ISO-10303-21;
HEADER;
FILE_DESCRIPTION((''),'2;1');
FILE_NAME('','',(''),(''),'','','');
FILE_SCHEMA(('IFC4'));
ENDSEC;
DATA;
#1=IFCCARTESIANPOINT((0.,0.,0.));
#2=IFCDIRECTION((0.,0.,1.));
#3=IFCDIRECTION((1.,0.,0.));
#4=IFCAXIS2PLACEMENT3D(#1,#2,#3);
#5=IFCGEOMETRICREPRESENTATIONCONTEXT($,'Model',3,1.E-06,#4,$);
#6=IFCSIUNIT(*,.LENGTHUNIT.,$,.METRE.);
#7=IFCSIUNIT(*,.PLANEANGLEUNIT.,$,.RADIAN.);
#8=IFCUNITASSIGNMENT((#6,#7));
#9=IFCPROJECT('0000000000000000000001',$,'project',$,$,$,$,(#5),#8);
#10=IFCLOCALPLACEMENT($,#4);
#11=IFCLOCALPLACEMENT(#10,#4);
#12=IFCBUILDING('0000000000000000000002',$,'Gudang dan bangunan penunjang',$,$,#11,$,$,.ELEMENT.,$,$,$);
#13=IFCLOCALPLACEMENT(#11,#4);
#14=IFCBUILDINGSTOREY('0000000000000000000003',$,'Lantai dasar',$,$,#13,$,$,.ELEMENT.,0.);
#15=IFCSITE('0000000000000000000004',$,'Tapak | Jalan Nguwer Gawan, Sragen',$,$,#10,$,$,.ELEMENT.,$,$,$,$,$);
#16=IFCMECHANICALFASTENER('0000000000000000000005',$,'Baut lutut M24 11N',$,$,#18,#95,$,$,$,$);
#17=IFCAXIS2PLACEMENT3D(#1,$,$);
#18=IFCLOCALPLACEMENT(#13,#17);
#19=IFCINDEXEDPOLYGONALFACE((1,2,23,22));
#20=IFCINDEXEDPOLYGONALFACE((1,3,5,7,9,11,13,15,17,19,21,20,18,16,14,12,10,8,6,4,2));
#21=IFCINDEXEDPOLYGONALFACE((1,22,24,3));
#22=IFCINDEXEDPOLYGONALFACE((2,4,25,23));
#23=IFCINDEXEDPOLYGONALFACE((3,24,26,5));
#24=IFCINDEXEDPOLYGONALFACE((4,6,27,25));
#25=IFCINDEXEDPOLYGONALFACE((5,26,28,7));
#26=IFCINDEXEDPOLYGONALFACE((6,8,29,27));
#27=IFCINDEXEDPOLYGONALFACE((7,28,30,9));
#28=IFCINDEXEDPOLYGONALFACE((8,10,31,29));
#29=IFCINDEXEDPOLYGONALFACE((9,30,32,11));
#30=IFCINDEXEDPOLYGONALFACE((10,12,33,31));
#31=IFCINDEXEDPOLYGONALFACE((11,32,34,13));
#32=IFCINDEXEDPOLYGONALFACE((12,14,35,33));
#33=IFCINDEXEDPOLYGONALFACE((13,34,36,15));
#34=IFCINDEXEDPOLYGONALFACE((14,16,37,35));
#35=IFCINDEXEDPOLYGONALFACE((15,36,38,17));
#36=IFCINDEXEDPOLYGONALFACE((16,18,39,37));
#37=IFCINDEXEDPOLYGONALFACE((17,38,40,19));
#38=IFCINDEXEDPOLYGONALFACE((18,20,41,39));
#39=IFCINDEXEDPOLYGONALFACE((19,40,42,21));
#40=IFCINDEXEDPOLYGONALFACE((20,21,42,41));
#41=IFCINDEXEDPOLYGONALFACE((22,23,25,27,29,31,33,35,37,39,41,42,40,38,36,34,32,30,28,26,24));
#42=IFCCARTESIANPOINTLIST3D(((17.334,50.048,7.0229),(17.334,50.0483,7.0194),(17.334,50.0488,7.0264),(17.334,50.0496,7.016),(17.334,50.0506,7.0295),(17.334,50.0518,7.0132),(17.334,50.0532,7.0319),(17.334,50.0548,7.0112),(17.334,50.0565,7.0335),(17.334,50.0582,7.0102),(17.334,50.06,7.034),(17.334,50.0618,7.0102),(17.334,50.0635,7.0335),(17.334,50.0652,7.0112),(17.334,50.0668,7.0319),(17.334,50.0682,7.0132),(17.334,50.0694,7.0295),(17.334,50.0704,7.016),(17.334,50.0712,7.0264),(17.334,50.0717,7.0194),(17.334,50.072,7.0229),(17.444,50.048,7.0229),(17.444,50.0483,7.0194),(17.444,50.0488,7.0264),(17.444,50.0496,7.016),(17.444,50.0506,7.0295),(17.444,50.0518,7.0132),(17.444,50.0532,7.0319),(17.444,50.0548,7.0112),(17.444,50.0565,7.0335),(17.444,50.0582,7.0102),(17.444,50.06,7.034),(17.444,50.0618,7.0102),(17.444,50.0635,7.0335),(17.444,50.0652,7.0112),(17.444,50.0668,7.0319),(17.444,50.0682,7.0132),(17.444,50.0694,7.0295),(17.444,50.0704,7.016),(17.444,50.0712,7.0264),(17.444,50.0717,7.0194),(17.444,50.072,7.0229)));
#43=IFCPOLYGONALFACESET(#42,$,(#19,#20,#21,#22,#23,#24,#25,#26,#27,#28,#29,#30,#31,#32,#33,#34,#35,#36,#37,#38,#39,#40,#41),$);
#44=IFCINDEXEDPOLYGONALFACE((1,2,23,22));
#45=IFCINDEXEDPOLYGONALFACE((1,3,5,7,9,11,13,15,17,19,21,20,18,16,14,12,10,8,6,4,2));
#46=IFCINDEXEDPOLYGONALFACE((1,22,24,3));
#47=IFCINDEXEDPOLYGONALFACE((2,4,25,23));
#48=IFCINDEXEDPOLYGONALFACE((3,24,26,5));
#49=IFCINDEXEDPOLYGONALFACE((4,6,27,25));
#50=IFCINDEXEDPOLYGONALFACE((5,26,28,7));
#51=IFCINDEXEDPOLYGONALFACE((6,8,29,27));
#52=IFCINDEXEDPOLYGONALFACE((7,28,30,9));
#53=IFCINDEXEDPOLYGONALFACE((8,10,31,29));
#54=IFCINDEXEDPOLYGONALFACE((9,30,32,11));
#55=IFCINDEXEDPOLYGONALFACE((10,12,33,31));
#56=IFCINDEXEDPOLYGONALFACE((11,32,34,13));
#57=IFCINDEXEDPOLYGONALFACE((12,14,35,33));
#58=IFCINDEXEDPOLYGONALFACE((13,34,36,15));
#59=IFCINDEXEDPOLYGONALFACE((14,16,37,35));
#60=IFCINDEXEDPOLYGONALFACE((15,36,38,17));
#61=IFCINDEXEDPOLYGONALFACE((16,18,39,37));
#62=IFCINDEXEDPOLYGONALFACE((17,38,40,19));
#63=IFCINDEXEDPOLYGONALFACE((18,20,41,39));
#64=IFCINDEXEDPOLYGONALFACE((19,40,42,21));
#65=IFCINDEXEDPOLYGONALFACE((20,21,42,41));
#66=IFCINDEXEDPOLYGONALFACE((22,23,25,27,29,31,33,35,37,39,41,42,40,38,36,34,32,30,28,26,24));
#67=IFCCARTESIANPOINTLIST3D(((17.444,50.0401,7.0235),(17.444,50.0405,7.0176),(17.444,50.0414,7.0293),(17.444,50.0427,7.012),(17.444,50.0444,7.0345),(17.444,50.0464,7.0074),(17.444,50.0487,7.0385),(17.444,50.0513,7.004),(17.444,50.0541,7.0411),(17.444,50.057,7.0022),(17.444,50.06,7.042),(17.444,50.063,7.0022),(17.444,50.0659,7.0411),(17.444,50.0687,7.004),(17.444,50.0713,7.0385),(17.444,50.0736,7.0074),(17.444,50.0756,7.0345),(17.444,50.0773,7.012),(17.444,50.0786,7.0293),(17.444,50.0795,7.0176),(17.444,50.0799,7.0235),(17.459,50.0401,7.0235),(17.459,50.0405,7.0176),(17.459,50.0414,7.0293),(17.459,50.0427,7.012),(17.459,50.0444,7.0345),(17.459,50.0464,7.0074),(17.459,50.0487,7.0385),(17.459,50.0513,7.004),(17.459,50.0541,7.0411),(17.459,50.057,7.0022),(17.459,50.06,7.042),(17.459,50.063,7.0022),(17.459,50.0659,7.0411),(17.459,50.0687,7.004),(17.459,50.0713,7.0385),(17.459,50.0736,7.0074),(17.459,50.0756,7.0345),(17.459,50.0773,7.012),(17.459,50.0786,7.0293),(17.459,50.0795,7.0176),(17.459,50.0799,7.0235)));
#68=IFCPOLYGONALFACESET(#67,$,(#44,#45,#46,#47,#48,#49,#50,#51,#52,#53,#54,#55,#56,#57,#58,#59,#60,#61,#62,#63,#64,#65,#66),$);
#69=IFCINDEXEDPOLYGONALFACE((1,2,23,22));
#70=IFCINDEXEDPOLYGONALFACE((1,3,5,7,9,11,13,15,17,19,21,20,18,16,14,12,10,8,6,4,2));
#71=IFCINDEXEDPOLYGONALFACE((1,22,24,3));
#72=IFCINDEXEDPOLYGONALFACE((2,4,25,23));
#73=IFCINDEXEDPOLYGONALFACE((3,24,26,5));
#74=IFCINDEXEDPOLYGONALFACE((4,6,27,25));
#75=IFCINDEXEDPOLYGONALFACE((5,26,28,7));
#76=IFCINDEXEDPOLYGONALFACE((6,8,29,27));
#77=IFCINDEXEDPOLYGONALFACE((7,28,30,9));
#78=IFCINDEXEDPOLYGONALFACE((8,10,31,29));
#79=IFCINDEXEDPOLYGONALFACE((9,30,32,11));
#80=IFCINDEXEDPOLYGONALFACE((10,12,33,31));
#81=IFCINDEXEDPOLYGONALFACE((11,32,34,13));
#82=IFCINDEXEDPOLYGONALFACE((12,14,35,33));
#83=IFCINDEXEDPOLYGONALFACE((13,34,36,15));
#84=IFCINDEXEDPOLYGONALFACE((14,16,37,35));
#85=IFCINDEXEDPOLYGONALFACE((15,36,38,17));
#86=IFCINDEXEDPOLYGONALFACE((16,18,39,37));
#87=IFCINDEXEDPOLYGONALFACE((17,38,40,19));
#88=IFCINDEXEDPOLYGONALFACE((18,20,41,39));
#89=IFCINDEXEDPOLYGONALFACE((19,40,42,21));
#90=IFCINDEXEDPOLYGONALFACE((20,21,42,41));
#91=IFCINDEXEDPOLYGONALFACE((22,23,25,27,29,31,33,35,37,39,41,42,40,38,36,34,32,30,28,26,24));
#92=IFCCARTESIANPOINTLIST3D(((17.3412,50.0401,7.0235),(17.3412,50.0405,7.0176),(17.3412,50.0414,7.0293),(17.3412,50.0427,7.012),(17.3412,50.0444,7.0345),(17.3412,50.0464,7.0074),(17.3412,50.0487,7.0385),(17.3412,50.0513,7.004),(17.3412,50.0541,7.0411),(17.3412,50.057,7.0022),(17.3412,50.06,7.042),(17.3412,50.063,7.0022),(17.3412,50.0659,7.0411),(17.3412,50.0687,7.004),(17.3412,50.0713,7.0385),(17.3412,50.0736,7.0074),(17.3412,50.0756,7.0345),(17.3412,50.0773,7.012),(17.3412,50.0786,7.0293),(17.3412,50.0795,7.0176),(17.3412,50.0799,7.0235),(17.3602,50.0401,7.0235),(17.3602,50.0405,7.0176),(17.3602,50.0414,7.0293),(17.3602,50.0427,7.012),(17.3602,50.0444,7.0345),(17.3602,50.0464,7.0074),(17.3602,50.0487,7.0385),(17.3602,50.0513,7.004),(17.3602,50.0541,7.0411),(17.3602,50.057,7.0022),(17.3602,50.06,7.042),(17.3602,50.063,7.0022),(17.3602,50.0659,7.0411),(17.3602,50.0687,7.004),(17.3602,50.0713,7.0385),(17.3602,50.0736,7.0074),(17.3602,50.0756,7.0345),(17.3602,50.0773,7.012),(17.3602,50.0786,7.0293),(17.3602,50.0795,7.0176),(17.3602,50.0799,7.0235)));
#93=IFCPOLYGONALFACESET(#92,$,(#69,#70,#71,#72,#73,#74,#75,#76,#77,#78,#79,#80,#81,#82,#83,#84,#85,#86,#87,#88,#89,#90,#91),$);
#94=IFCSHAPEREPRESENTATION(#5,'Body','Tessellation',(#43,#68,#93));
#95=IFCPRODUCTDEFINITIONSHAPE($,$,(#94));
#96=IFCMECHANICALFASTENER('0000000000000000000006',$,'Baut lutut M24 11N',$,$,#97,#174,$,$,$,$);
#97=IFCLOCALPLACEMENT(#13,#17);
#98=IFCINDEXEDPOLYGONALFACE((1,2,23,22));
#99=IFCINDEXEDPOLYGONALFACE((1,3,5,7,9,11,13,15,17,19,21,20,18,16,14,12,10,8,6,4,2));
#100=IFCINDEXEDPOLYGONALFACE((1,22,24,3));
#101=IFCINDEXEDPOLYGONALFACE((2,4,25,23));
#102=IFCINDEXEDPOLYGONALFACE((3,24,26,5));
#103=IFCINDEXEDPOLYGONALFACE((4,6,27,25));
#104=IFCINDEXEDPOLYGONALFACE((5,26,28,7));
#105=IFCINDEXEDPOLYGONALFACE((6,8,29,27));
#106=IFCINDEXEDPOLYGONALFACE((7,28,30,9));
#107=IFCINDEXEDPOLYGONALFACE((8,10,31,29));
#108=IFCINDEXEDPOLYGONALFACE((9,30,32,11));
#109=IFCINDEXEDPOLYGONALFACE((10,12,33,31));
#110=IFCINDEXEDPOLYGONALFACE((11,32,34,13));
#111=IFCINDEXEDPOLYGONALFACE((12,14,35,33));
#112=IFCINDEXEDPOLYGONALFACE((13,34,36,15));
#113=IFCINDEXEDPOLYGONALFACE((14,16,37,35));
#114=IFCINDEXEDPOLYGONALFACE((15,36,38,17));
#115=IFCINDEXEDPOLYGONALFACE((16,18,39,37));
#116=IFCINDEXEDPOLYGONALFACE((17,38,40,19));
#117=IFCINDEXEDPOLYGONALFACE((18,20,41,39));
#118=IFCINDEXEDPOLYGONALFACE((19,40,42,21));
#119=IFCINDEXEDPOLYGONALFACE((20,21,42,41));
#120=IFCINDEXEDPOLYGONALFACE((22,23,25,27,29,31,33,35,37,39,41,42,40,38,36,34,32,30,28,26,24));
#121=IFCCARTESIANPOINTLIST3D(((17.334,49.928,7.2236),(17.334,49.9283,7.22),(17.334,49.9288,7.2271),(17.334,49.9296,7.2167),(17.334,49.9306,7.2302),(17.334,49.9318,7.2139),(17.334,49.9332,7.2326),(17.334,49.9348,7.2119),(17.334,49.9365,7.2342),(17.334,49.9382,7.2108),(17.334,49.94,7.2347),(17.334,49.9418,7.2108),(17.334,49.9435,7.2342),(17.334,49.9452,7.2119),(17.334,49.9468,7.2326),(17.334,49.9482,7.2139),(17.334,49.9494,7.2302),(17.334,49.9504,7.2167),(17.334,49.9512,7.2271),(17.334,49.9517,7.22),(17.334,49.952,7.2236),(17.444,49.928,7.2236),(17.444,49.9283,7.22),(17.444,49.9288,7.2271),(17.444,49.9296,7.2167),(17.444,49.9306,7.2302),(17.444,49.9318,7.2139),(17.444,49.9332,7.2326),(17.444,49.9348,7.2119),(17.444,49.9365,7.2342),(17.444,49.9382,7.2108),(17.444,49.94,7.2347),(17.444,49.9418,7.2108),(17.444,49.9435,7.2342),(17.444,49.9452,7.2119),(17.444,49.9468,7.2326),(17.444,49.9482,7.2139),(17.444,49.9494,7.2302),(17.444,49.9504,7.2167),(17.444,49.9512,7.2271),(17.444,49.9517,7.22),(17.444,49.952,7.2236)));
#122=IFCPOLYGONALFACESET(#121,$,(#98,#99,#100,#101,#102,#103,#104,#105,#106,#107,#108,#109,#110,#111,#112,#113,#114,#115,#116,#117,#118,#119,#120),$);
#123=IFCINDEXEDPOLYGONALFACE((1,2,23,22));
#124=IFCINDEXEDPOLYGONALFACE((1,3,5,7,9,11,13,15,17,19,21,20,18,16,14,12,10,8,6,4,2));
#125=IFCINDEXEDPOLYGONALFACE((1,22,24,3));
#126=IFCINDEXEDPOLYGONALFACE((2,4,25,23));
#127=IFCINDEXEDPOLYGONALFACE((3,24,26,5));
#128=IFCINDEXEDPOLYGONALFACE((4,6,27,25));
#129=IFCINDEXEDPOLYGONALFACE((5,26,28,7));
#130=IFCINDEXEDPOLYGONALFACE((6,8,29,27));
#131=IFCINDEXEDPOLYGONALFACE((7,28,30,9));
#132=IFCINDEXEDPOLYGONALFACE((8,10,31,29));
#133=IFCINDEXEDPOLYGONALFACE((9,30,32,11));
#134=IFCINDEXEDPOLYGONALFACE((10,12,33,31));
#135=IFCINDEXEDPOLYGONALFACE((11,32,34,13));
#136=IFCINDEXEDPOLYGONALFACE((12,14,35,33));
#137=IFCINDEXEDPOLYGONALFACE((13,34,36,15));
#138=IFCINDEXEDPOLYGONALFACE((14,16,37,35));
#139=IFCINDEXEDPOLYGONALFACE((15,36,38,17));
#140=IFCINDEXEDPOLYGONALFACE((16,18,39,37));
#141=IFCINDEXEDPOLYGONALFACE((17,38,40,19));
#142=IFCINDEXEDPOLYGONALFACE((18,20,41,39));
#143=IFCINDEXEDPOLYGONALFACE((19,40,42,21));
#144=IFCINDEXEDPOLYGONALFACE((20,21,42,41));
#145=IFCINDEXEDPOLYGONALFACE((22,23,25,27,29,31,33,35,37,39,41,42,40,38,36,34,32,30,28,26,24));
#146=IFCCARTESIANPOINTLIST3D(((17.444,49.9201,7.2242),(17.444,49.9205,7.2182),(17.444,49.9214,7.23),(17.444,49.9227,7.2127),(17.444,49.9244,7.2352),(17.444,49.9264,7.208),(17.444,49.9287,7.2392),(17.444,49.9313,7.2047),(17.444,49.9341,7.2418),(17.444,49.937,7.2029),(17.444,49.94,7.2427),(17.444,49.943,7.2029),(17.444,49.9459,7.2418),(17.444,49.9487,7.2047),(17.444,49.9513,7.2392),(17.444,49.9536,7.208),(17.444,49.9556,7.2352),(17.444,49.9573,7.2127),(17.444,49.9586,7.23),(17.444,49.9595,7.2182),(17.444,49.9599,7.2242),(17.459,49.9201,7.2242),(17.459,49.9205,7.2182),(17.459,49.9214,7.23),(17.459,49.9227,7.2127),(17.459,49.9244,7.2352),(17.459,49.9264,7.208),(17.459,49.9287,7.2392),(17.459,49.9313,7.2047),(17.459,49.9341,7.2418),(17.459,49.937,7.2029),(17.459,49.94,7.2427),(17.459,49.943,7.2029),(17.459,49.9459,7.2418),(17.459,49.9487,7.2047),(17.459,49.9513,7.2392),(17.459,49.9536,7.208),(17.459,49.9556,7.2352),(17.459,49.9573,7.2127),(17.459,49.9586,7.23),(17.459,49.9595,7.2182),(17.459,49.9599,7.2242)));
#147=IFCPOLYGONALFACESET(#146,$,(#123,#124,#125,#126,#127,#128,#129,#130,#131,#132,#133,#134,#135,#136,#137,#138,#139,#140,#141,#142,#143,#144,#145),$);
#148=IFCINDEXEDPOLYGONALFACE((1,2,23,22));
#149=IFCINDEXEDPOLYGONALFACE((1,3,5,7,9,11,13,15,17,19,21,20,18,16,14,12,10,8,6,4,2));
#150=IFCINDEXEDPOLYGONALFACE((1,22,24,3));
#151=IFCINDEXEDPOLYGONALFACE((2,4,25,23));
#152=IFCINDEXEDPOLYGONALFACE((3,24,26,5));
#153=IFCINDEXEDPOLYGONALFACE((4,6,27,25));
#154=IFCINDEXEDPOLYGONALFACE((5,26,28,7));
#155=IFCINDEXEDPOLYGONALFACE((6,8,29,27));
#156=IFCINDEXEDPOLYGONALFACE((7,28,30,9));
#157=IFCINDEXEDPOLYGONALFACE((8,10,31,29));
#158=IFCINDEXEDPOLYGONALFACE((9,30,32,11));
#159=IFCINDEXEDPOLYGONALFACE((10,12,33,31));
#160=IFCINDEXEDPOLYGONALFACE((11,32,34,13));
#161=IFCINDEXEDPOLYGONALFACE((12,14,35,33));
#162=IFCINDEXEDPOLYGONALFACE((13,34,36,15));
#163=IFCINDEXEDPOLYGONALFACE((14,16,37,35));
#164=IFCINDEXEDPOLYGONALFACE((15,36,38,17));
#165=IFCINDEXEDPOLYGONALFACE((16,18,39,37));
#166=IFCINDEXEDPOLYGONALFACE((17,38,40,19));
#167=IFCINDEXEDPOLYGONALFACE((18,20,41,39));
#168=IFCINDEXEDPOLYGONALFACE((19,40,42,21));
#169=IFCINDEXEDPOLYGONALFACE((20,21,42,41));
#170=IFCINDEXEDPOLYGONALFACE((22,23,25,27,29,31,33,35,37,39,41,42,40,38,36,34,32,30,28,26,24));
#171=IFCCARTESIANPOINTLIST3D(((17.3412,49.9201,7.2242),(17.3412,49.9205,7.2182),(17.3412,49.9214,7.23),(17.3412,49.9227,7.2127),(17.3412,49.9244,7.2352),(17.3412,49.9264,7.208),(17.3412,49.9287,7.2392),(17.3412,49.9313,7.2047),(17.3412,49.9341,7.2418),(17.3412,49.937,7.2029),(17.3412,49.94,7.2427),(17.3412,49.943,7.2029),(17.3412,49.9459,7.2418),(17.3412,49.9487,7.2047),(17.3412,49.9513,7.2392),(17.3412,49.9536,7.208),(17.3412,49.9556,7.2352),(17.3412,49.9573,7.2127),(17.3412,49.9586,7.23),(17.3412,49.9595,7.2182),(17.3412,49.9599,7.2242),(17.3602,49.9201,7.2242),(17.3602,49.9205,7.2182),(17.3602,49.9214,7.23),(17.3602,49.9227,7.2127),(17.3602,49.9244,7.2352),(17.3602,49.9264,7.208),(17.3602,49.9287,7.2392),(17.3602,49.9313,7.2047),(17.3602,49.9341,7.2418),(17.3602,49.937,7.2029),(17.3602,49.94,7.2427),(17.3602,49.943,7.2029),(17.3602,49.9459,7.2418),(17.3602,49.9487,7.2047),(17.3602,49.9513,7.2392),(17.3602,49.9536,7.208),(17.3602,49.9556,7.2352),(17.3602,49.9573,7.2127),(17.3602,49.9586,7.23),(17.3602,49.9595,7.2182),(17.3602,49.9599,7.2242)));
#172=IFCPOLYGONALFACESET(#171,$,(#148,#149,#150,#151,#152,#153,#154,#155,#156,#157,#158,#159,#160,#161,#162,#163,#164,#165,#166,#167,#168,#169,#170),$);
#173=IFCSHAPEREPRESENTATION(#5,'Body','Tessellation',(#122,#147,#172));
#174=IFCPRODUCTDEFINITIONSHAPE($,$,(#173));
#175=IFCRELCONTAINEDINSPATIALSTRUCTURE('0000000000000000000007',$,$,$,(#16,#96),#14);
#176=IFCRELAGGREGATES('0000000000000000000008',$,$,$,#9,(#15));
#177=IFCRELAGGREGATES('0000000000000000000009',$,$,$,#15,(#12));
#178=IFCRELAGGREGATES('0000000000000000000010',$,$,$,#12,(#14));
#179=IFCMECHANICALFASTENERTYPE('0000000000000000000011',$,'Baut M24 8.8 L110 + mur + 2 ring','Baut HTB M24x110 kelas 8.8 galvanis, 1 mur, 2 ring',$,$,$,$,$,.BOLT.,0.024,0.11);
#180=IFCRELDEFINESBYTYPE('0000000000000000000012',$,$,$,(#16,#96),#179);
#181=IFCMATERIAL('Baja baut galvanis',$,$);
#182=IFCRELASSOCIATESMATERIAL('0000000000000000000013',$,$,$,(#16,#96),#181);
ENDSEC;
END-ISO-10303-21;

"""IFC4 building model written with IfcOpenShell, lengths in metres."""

from ifc_helpers import new_model, si_unit, frame, origin_with_axes, place, context, project, spatial, circle, extrude, source, transform, mapped, material, type_object, type_shapes, element, save


model = new_model("IFC4")

# Units and contexts
model_context = context("Model", 3, precision=1e-06, world=origin_with_axes())
ifc_project = project(units=[si_unit("LENGTHUNIT", "METRE"), si_unit("PLANEANGLEUNIT", "RADIAN")], contexts=[model_context])

# Site, building, storey
site_placement = place(None, origin_with_axes())
site = spatial("IfcSite", under=ifc_project, at=site_placement, Name="Tapak | Jalan Nguwer Gawan, Sragen", CompositionType="ELEMENT")
building_placement = place(site_placement, origin_with_axes())
building = spatial("IfcBuilding", under=site, at=building_placement, Name="Gudang dan bangunan penunjang", CompositionType="ELEMENT")
storey_placement = place(building_placement, origin_with_axes())
storey = spatial("IfcBuildingStorey", under=building, at=storey_placement, Name="Lantai dasar", CompositionType="ELEMENT", Elevation=0.0)

# Shared definitions
placement = place(None, origin_with_axes())

# Mechanical fasteners
ifc_material_1 = material(Name="Baja baut galvanis")
mechanical_fastener_type_1 = type_object("IfcMechanicalFastenerType", Name="Baut M24 8.8 L110 + mur + 2 ring", Description="Baut HTB M24x110 kelas 8.8 galvanis, 1 mur, 2 ring", NominalDiameter=0.024, NominalLength=0.11, PredefinedType="BOLT")
shared_shape_1 = source(origin_with_axes(), model_context, "Body", "SweptSolid", [
    extrude(circle(Radius=0.012), origin_with_axes(), (0.0, 0.0, 1.0), 0.11),
    extrude(circle(Radius=0.02), frame((0.0, 0.0, -0.015), z_axis=(0.0, 0.0, 1.0), x_axis=(1.0, 0.0, 0.0)), (0.0, 0.0, 1.0), 0.015),
    extrude(circle(Radius=0.02), frame((0.0, 0.0, 0.0838), z_axis=(0.0, 0.0, 1.0), x_axis=(1.0, 0.0, 0.0)), (0.0, 0.0, 1.0), 0.019),
])
type_shapes(mechanical_fastener_type_1, [shared_shape_1])
element("IfcMechanicalFastener", 1, at=placement, inside=storey, type_object=mechanical_fastener_type_1, material=ifc_material_1, Name="Baut lutut M24 11N", context=model_context, shape_type="MappedRepresentation", body=[
    mapped(shared_shape_1, transform((17.444, 50.06, 7.022), x_axis=(0.0, 0.0, 1.0), y_axis=(0.0, 1.0, 0.0), z_axis=(-1.0, 0.0, 0.0), scale=1.0)),
])
element("IfcMechanicalFastener", 2, at=placement, inside=storey, type_object=mechanical_fastener_type_1, material=ifc_material_1, Name="Baut lutut M24 11N", context=model_context, shape_type="MappedRepresentation", body=[
    mapped(shared_shape_1, transform((17.444, 49.94, 7.2227), x_axis=(0.0, 0.0, 1.0), y_axis=(0.0, 1.0, 0.0), z_axis=(-1.0, 0.0, 0.0), scale=1.0)),
])

save(model, "model.ifc")
